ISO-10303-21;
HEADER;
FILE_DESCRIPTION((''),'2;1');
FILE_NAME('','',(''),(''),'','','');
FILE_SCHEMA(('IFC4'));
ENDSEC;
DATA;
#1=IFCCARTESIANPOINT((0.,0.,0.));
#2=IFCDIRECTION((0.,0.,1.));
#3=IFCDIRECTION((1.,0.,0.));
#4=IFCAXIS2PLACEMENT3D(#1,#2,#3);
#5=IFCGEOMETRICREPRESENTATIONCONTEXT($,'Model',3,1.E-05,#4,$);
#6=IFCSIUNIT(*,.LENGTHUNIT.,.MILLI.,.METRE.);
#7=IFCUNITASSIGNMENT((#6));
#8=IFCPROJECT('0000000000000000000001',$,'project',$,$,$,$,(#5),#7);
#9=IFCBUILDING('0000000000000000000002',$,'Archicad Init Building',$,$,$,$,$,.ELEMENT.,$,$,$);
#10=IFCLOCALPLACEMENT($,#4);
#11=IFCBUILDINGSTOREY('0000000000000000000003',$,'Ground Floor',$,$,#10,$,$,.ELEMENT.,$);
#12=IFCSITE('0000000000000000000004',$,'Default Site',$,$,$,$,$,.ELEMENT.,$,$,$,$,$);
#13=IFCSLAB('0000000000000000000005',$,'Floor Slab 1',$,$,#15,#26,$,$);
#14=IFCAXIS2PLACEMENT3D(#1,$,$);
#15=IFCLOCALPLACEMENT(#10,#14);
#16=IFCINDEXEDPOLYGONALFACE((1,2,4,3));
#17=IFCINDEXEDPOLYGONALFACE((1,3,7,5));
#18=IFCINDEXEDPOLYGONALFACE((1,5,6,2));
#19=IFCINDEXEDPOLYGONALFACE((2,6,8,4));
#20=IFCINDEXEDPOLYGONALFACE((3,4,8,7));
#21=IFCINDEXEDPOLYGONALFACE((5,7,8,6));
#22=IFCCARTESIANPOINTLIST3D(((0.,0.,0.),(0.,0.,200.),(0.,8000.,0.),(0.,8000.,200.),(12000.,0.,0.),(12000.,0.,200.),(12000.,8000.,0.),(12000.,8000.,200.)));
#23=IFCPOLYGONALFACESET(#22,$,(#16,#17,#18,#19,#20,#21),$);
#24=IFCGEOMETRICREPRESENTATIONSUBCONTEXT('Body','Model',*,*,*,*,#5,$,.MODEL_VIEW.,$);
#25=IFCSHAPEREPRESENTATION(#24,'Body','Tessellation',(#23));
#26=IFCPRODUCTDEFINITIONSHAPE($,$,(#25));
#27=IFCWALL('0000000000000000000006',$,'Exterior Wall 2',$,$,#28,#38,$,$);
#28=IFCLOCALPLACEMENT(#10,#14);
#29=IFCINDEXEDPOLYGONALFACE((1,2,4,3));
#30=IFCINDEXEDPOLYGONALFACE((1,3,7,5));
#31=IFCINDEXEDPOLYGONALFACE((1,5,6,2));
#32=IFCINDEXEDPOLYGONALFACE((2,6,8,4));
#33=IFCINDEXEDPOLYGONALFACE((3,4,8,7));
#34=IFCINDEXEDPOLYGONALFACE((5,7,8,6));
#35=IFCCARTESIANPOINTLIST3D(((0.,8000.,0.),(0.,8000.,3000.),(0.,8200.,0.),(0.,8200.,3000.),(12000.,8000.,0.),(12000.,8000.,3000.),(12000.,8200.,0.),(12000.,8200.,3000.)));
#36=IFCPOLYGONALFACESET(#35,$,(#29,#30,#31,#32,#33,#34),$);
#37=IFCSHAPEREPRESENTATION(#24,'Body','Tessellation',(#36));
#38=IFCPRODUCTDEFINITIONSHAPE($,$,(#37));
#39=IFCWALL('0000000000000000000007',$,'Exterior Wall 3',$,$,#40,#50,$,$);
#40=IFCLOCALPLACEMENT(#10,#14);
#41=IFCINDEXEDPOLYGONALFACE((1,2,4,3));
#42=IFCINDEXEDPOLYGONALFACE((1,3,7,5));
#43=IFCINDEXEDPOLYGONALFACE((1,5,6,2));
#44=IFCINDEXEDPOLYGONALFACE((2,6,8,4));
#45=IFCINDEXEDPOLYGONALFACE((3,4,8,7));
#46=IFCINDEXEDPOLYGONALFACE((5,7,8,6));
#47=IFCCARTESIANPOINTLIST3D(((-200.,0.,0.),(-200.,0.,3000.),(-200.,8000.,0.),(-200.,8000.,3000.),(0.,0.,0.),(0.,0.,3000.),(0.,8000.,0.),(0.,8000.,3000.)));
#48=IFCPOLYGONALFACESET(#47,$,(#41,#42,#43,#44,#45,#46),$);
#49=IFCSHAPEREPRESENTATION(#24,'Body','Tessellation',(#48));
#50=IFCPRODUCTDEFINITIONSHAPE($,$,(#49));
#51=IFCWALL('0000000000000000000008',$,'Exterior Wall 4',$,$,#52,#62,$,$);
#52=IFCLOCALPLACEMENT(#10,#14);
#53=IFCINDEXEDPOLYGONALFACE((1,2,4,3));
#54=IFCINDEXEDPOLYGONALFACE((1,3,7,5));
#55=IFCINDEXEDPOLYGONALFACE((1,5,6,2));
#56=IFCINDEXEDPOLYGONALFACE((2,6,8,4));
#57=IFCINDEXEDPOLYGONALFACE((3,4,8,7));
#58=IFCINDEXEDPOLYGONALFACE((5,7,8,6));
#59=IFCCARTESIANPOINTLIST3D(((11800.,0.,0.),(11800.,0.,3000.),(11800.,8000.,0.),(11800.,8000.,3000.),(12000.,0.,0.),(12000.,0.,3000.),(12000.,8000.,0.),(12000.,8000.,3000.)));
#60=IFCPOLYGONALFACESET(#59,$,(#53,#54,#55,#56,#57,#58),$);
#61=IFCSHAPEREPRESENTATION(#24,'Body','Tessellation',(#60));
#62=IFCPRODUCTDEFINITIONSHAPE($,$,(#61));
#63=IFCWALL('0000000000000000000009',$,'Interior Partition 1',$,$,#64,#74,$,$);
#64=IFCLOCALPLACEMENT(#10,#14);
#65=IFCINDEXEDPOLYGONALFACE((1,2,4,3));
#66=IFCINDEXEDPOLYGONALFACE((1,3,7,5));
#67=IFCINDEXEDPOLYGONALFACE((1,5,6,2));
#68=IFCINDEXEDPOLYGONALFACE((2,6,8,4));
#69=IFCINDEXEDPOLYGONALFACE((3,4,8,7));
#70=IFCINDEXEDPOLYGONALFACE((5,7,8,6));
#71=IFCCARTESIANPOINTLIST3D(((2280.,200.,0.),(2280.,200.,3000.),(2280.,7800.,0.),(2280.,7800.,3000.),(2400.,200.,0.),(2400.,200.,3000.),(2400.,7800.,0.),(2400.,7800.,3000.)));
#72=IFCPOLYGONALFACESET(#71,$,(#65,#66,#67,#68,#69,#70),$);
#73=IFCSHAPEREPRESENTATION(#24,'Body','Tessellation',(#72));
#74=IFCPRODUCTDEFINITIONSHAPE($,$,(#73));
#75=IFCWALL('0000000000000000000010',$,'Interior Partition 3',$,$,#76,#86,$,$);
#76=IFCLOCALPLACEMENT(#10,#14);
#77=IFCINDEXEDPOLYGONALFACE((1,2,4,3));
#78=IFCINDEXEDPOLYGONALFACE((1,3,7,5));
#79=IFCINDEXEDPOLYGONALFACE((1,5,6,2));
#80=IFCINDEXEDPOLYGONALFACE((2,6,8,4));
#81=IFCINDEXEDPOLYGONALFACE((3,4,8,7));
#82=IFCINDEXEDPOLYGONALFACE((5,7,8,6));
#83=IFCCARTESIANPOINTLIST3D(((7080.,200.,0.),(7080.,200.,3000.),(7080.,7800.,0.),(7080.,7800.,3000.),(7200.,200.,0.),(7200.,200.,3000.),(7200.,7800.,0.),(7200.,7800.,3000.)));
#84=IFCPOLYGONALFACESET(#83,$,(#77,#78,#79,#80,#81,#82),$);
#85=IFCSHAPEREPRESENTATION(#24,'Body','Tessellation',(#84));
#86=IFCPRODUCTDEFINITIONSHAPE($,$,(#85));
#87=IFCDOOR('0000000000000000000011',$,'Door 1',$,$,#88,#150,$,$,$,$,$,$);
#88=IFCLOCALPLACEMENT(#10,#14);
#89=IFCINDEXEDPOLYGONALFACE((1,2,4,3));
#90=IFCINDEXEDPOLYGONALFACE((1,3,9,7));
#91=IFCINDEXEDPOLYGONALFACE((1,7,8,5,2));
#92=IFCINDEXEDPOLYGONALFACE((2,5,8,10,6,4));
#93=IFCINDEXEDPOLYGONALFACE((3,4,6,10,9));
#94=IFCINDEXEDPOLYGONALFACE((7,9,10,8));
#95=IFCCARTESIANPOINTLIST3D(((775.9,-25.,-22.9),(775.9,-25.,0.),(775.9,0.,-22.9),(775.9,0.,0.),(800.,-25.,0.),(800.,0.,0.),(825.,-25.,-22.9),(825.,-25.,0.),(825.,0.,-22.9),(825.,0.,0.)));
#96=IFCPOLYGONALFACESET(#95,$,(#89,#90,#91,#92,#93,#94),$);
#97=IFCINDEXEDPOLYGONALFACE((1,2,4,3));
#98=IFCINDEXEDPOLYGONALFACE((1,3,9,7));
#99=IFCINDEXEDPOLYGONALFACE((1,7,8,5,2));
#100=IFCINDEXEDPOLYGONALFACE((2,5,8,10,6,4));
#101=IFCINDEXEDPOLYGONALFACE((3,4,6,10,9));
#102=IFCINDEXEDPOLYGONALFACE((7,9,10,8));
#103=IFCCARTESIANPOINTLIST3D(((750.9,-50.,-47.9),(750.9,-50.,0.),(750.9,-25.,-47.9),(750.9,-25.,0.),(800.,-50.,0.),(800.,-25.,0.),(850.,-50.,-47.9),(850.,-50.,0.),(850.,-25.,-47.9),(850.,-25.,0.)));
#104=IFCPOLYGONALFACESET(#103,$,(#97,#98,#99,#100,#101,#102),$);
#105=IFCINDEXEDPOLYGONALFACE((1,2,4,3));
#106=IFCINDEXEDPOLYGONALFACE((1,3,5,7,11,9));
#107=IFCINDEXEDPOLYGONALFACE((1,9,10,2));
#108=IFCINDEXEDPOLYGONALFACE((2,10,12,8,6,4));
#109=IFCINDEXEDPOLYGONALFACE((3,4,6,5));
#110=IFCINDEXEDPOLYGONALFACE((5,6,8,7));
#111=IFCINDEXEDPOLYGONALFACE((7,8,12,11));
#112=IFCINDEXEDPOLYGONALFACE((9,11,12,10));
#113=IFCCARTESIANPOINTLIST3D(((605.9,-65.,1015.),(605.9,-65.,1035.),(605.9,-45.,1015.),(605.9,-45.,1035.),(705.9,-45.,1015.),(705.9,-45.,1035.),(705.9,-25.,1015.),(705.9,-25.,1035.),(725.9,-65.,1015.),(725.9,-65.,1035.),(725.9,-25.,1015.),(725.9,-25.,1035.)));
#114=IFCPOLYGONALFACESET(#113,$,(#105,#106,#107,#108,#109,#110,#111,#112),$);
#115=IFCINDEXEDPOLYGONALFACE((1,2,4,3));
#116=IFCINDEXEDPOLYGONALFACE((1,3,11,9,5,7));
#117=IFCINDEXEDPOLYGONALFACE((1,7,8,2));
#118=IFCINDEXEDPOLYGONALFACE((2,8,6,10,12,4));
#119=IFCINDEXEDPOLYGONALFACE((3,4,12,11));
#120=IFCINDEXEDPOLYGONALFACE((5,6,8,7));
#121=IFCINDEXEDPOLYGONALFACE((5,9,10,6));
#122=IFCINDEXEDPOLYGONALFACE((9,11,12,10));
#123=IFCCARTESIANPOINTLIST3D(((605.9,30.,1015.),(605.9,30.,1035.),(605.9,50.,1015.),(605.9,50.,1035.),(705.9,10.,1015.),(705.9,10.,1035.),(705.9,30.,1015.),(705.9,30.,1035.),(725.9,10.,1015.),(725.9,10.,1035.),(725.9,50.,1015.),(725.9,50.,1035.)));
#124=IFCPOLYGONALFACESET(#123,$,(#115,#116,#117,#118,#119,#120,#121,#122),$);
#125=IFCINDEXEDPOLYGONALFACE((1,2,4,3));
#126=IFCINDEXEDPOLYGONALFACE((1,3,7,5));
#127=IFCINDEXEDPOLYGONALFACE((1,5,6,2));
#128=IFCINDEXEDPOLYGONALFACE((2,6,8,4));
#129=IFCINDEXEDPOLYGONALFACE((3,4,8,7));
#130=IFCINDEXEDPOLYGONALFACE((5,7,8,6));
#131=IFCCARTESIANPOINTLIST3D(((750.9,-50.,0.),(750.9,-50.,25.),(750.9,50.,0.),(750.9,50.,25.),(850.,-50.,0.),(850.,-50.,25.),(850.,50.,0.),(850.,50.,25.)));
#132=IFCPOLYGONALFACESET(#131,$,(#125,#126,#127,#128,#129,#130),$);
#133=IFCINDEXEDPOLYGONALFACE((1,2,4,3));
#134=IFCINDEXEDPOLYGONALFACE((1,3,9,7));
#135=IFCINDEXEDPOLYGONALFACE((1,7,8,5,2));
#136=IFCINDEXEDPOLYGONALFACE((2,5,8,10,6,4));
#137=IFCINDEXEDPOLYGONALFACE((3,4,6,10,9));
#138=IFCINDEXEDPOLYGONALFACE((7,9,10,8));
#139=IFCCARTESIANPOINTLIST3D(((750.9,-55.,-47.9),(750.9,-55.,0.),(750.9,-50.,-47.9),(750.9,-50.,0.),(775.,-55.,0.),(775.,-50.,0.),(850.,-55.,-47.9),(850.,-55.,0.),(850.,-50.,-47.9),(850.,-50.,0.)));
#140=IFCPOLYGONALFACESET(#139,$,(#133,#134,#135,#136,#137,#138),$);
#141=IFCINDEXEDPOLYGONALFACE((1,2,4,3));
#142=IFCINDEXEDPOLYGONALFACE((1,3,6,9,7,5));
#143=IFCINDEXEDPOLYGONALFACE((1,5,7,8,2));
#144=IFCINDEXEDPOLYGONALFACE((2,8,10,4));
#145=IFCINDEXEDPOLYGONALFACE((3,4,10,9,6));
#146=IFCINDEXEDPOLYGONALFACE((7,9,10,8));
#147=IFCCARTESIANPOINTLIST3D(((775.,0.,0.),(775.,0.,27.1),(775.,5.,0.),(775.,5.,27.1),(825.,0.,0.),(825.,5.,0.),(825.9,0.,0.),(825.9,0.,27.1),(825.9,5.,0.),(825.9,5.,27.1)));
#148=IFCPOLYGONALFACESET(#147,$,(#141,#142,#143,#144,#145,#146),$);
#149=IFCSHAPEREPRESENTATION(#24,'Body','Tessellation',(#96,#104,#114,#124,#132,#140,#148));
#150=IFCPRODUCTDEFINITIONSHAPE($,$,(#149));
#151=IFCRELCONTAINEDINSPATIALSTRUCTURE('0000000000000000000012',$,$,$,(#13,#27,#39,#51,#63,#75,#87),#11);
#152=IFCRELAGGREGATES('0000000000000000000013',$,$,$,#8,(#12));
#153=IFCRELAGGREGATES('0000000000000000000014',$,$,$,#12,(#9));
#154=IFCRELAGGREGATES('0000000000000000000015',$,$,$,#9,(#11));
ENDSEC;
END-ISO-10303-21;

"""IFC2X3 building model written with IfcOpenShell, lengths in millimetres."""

from ifc_helpers import new_model, si_unit, frame, origin_with_axes, place, context, subcontext, project, spatial, polyline, outline, extrude, element, save


model = new_model("IFC2X3")

# Units and contexts
model_context = context("Model", 3, precision=1e-05, world=origin_with_axes())
body_context = subcontext(model_context, "Body", "Model", "MODEL_VIEW")
ifc_project = project(units=[si_unit("LENGTHUNIT", "METRE", prefix="MILLI")], contexts=[model_context])

# Site, building, storey
site = spatial("IfcSite", under=ifc_project, Name="Default Site", CompositionType="ELEMENT")
building = spatial("IfcBuilding", under=site, Name="Archicad Init Building", CompositionType="ELEMENT")
storey_placement = place(None, origin_with_axes())
storey = spatial("IfcBuildingStorey", under=building, at=storey_placement, Name="Ground Floor", CompositionType="ELEMENT")

# Slab
slab_placement = place(storey_placement, origin_with_axes())
element("IfcSlab", 1, at=slab_placement, inside=storey, Name="Floor Slab 1", context=body_context, shape_type="SweptSolid", body=[
    extrude(outline(polyline([(0.0, 0.0), (12000.0, 0.0), (12000.0, 8000.0), (0.0, 8000.0), (0.0, 0.0)])), origin_with_axes(), (0.0, 0.0, 1.0), 200.0),
])

# Walls
wall_placement = place(storey_placement, frame((0.0, 8000.0, 0.0), z_axis=(0.0, 0.0, 1.0), x_axis=(1.0, 0.0, 0.0)))
element("IfcWall", 2, at=wall_placement, inside=storey, Name="Exterior Wall 2", context=body_context, shape_type="SweptSolid", body=[
    extrude(outline(polyline([(0.0, 0.0), (0.0, 200.0), (12000.0, 200.0), (12000.0, 0.0), (0.0, 0.0)])), origin_with_axes(), (0.0, 0.0, 1.0), 3000.0),
])
for number, where, z_axis, x_axis, name in (
    (3, (0.0, 0.0, 0.0), (0.0, 0.0, 1.0), (0.0, 1.0, 0.0), "Exterior Wall 3"),
    (4, (12000.0, 0.0, 0.0), (0.0, 0.0, 1.0), (0.0, 1.0, 0.0), "Exterior Wall 4"),
):
    element("IfcWall", number, at=place(storey_placement, frame(where, z_axis=z_axis, x_axis=x_axis)), inside=storey, Name=name, context=body_context, shape_type="SweptSolid", body=[
        extrude(outline(polyline([(0.0, 0.0), (0.0, 200.0), (8000.0, 200.0), (8000.0, 0.0), (0.0, 0.0)])), origin_with_axes(), (0.0, 0.0, 1.0), 3000.0),
    ])
for number, where, z_axis, x_axis, name in (
    (5, (2400.0, 200.0, 0.0), (0.0, 0.0, 1.0), (0.0, 1.0, 0.0), "Interior Partition 1"),
    (6, (7200.0, 200.0, 0.0), (0.0, 0.0, 1.0), (0.0, 1.0, 0.0), "Interior Partition 3"),
):
    element("IfcWall", number, at=place(storey_placement, frame(where, z_axis=z_axis, x_axis=x_axis)), inside=storey, Name=name, context=body_context, shape_type="SweptSolid", body=[
        extrude(outline(polyline([(0.0, 0.0), (0.0, 120.0), (7600.0, 120.0), (7600.0, 0.0), (0.0, 0.0)])), origin_with_axes(), (0.0, 0.0, 1.0), 3000.0),
    ])

# Door
door_1_placement = place(storey_placement, frame((800.0, -50.0, 0.0), z_axis=(0.0, 0.0, 1.0), x_axis=(1.0, 0.0, 0.0)))
element("IfcDoor", 7, at=door_1_placement, inside=storey, Name="Door 1", context=body_context, shape_type="SweptSolid", body=[
    extrude(outline(polyline([(0.0, 0.0), (0.0, 2.1), (0.9, 2.1), (0.9, 0.0), (-24.1, 0.0), (-24.1, -22.9), (25.0, -22.9), (25.0, 0.0), (0.0, 0.0)])), frame((0.0, 25.0, 0.0), z_axis=(0.0, -1.0, 0.0), x_axis=(1.0, 0.0, 0.0)), (0.0, 0.0, -1.0), 25.0),
    extrude(outline(polyline([(0.0, 0.0), (0.0, 2.1), (0.9, 2.1), (0.9, 0.0), (-49.1, 0.0), (-49.1, -47.9), (50.0, -47.9), (50.0, 0.0), (0.0, 0.0)])), frame((0.0, 0.0, 0.0), z_axis=(0.0, -1.0, 0.0), x_axis=(1.0, 0.0, 0.0)), (0.0, 0.0, -1.0), 25.0),
    extrude(outline(polyline([(0.0, 0.0), (-49.1, 0.0), (-49.1, 35.0), (0.0, 35.0), (0.0, 0.0)])), frame((25.0, 25.0, 25.0), z_axis=(0.0, 0.0, 1.0), x_axis=(1.0, 0.0, 0.0)), (0.0, 0.0, 1.0), -47.9),
    extrude(outline(polyline([(0.0, 0.0), (0.0, -40.0), (-120.0, -40.0), (-120.0, -20.0), (-20.0, -20.0), (-20.0, 0.0), (0.0, 0.0)])), frame((-74.1, 25.0, 1015.0), z_axis=(0.0, 0.0, 1.0), x_axis=(1.0, 0.0, 0.0)), (0.0, 0.0, 1.0), 20.0),
    extrude(outline(polyline([(0.0, 0.0), (0.0, 40.0), (-120.0, 40.0), (-120.0, 20.0), (-20.0, 20.0), (-20.0, 0.0), (0.0, 0.0)])), frame((-74.1, 60.0, 1015.0), z_axis=(0.0, 0.0, 1.0), x_axis=(1.0, 0.0, 0.0)), (0.0, 0.0, 1.0), 20.0),
    extrude(outline(polyline([(0.0, 0.0), (-99.1, 0.0), (-99.1, 100.0), (0.0, 100.0), (0.0, 0.0)])), frame((50.0, 0.0, 0.0), z_axis=(0.0, 0.0, 1.0), x_axis=(1.0, 0.0, 0.0)), (0.0, 0.0, 1.0), 25.0),
    extrude(outline(polyline([(0.0, 0.0), (0.0, 27.1), (50.9, 27.1), (50.9, 0.0), (-24.1, 0.0), (-24.1, -47.9), (75.0, -47.9), (75.0, 0.0), (0.0, 0.0)])), frame((-25.0, -5.0, 0.0), z_axis=(0.0, -1.0, 0.0), x_axis=(1.0, 0.0, 0.0)), (0.0, 0.0, -1.0), 5.0),
    extrude(outline(polyline([(0.0, 0.0), (0.0, 27.1), (50.9, 27.1), (50.9, 0.0), (0.9, 0.0), (0.9, -22.9), (50.0, -22.9), (50.0, 0.0), (0.0, 0.0)])), frame((-25.0, 50.0, 0.0), z_axis=(0.0, -1.0, 0.0), x_axis=(1.0, 0.0, 0.0)), (0.0, 0.0, -1.0), 5.0),
])

save(model, "model.ifc")
